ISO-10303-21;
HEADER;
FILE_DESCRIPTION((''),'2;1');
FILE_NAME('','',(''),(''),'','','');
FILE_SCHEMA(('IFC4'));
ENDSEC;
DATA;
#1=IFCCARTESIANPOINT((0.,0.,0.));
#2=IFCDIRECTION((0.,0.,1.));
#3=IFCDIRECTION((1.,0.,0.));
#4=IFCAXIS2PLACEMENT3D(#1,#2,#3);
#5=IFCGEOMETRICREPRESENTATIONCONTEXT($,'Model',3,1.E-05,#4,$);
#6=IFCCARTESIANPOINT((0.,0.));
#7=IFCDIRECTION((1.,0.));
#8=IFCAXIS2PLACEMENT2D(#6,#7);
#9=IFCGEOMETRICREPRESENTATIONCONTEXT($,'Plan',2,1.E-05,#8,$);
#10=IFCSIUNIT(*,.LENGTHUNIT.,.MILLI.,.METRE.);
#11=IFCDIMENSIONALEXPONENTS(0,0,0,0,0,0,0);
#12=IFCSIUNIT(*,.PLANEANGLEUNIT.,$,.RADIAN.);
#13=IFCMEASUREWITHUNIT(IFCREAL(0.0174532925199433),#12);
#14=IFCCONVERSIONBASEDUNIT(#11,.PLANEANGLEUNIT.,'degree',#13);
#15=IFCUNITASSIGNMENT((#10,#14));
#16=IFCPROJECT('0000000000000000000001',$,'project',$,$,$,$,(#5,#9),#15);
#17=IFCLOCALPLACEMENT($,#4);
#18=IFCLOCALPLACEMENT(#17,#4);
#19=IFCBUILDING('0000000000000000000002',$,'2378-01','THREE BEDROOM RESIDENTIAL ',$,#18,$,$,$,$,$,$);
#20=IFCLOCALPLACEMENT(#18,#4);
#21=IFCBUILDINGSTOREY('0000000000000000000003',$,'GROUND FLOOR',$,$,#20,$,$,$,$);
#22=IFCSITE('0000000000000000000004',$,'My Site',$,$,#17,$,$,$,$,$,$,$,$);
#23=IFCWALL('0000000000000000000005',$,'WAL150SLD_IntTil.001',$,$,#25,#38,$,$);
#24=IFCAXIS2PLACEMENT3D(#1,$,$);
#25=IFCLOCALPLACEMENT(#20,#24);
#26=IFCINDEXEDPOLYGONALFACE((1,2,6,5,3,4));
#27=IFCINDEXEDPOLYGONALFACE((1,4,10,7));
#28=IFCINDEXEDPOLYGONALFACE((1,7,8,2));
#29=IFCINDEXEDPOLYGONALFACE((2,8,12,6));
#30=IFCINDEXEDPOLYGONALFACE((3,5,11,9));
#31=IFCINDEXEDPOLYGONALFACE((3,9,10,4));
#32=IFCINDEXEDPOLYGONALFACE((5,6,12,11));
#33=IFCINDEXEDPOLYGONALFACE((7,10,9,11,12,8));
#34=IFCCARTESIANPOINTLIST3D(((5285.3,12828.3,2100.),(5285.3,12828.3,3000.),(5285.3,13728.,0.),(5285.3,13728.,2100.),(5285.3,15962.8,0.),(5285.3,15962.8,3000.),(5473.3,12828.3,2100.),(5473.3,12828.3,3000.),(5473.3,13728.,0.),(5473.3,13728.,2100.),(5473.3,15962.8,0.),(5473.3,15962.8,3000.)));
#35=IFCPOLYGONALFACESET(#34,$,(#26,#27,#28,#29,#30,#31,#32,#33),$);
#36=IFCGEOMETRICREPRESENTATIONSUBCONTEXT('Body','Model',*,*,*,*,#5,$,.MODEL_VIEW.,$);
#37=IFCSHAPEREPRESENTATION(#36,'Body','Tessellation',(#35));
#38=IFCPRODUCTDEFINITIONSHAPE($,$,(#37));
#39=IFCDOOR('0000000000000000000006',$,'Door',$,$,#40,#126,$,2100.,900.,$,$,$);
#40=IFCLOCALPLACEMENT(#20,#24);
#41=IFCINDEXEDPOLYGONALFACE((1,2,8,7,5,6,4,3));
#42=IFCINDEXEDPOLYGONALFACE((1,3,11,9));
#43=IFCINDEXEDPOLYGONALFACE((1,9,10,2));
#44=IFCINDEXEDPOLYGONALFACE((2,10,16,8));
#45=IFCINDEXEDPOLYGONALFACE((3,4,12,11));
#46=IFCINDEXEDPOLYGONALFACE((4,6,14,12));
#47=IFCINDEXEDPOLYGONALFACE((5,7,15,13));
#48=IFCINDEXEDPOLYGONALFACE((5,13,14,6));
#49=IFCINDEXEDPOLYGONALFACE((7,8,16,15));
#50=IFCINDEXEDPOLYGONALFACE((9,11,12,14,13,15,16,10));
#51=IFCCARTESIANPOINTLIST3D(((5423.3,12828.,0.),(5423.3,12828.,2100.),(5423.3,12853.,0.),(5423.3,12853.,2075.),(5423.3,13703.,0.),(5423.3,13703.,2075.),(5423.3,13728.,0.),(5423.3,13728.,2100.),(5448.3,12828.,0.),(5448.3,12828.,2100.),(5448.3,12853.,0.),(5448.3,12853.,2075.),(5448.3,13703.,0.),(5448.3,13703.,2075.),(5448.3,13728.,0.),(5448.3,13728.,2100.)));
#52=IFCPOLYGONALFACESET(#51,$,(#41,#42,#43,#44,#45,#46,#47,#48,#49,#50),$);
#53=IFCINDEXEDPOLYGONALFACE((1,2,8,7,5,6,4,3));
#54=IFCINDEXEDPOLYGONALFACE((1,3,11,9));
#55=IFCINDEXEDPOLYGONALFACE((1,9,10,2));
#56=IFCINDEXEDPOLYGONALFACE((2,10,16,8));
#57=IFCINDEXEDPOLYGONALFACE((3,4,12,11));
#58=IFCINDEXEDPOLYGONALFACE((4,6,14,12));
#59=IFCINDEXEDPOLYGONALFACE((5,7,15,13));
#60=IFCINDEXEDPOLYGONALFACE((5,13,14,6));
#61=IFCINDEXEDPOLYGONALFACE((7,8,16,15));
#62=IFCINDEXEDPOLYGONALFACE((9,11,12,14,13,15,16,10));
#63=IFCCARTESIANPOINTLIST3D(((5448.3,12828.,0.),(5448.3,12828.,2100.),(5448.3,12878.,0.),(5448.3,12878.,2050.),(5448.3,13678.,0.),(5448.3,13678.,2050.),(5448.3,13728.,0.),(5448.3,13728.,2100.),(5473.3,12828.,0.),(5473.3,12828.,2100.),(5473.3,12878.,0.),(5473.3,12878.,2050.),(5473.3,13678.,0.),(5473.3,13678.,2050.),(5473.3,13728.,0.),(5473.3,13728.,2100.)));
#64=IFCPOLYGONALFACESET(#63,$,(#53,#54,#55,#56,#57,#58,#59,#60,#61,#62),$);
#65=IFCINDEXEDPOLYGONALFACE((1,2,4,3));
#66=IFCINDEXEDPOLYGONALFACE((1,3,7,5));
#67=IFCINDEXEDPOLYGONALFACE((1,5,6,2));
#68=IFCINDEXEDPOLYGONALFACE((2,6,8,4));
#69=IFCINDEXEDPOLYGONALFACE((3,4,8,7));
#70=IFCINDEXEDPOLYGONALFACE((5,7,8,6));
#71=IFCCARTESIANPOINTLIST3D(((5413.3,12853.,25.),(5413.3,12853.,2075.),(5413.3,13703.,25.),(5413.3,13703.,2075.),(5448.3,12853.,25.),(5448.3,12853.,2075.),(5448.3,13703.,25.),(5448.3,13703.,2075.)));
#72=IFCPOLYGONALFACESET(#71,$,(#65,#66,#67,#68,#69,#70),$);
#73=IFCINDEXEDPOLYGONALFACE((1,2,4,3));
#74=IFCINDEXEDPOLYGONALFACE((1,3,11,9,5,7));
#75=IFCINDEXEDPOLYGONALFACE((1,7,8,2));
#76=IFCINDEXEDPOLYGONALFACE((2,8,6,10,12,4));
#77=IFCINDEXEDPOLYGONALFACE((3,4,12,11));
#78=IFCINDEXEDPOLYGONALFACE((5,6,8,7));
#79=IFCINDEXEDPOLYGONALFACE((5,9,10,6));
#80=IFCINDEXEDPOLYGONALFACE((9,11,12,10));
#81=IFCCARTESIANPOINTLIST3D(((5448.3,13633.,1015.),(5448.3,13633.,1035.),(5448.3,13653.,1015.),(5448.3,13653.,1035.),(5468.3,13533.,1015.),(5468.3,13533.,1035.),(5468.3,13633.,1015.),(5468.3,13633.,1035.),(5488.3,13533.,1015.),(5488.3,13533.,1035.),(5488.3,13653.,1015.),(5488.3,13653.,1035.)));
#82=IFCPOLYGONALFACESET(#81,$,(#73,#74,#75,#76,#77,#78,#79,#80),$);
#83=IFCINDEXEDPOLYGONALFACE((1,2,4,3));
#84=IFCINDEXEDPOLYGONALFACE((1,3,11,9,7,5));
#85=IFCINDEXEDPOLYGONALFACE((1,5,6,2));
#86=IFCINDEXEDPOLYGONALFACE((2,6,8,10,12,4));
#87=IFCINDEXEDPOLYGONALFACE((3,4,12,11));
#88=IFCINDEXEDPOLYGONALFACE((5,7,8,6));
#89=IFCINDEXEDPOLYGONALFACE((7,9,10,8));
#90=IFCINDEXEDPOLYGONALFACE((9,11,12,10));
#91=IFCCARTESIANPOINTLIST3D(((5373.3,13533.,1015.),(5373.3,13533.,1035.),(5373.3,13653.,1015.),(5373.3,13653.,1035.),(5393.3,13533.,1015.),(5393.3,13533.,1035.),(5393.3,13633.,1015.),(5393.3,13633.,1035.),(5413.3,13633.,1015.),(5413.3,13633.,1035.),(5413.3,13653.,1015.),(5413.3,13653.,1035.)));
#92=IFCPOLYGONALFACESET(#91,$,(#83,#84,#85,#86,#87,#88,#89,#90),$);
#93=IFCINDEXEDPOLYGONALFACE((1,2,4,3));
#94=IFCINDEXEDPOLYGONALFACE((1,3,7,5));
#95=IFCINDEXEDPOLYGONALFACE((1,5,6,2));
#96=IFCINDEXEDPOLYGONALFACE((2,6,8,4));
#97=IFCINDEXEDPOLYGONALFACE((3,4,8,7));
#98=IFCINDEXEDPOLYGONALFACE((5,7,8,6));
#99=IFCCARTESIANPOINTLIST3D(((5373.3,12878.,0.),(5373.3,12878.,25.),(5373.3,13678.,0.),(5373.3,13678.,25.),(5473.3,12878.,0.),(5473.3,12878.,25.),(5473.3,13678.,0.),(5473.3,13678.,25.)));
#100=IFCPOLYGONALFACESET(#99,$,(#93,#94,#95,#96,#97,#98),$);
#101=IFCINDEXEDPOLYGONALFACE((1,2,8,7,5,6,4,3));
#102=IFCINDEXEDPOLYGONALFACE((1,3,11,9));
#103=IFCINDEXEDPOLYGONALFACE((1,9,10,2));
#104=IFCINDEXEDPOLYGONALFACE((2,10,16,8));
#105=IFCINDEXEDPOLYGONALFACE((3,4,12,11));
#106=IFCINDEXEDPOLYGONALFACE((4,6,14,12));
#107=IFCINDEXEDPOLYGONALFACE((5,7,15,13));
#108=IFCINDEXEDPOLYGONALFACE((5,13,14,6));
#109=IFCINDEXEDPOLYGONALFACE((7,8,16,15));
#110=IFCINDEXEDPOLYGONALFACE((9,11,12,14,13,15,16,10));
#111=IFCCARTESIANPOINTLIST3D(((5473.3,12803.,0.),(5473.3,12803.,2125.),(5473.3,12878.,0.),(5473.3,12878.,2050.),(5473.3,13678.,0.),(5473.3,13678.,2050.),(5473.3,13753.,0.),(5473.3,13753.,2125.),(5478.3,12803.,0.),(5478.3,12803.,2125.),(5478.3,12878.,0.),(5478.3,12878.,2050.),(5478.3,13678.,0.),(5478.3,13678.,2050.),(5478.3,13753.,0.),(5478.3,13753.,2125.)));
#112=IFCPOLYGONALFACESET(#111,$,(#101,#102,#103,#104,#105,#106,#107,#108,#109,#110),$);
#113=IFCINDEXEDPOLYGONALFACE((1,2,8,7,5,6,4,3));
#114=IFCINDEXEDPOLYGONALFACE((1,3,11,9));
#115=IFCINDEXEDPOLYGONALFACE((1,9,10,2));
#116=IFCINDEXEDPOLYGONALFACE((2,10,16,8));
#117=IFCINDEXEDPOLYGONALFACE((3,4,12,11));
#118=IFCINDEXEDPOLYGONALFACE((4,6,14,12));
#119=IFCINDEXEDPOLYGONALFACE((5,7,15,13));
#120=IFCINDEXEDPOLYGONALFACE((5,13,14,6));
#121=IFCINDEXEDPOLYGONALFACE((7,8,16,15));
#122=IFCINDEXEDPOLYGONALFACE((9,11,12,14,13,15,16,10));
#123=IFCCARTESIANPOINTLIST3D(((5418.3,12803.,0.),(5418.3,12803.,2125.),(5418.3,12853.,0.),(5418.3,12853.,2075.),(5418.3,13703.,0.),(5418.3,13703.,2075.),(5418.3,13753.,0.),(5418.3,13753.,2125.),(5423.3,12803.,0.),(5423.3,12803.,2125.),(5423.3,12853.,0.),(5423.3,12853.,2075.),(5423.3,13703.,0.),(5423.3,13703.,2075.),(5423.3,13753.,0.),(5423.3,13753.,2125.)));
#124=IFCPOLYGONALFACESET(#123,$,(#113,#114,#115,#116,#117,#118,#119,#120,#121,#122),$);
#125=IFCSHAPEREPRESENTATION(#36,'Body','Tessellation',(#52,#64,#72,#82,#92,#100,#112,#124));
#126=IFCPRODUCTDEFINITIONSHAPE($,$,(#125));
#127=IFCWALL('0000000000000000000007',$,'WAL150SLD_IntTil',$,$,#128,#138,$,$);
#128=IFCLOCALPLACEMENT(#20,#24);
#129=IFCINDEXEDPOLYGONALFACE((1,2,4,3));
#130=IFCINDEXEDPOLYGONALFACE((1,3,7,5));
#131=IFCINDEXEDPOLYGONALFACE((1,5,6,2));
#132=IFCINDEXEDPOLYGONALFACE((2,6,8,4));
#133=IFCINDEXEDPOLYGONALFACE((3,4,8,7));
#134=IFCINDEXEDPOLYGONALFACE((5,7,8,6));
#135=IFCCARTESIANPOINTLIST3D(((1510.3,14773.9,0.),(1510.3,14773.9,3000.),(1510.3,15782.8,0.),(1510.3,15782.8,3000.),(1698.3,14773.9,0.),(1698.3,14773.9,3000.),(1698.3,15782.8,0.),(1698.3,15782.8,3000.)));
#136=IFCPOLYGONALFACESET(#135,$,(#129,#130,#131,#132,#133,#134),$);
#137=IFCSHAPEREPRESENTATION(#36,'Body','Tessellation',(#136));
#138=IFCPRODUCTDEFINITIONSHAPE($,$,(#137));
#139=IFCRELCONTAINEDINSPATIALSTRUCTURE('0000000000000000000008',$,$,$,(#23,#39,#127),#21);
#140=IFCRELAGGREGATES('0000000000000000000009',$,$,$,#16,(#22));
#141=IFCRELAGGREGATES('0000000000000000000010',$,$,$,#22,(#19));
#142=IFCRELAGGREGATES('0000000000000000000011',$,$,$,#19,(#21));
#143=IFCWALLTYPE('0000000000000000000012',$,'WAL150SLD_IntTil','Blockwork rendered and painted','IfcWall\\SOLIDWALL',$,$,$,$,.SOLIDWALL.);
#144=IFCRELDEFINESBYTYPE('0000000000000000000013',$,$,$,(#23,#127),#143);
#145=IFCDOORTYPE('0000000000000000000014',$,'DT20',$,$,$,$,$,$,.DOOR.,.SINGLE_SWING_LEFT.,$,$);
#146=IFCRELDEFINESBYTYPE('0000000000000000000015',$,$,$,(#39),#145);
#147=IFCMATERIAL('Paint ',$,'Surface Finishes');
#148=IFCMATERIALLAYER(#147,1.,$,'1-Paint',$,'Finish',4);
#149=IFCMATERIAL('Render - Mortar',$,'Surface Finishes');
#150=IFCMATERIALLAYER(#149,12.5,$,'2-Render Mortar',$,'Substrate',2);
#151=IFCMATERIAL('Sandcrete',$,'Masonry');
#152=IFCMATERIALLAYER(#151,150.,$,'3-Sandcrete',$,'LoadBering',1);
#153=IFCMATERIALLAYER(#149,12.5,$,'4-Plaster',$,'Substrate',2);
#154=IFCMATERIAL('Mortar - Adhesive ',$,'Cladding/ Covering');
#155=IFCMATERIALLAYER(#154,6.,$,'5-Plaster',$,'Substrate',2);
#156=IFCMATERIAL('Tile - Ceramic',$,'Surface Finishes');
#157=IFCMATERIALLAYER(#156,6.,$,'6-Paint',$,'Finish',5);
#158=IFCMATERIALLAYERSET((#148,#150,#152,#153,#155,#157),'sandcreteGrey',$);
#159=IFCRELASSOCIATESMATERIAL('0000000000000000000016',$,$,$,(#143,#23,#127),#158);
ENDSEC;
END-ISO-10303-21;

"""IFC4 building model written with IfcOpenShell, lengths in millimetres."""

from ifc_helpers import new_model, entity, si_unit, converted_unit, frame, origin_with_axes, origin_2d_with_axis, place, context, subcontext, project, spatial, line, indexed_curve, outline, extrude, shape, source, transform, mapped, material, layer, layer_set, layer_usage, type_object, type_shapes, element, fill, save


model = new_model("IFC4")

# Units and contexts
model_context = context("Model", 3, precision=1e-05, world=origin_with_axes())
plan_context = context("Plan", 2, precision=1e-05, world=origin_2d_with_axis())
body_context_1 = subcontext(model_context, "Body", "Model", "MODEL_VIEW")
body_context_2 = subcontext(plan_context, "Body", "Plan", "PLAN_VIEW")
ifc_project = project(units=[si_unit("LENGTHUNIT", "METRE", prefix="MILLI"), converted_unit("PLANEANGLEUNIT", "degree", entity("IfcReal", 0.0174532925199433), si_unit("PLANEANGLEUNIT", "RADIAN"), dimensions=[0, 0, 0, 0, 0, 0, 0])], contexts=[model_context, plan_context])

# Site, building, storey
site_placement = place(None, origin_with_axes())
site = spatial("IfcSite", under=ifc_project, at=site_placement, Name="My Site")
building_placement = place(site_placement, origin_with_axes())
building = spatial("IfcBuilding", under=site, at=building_placement, Name="2378-01", Description="THREE BEDROOM RESIDENTIAL ")
storey_placement = place(building_placement, origin_with_axes())
storey = spatial("IfcBuildingStorey", under=building, at=storey_placement, Name="GROUND FLOOR")

# Shared definitions
ifc_material_1 = material(Name="Paint ", Category="Surface Finishes")
ifc_material_2 = material(Name="Render - Mortar", Category="Surface Finishes")
ifc_material_3 = material(Name="Sandcrete", Category="Masonry")

# Shared definitions
ifc_material_4 = material(Name="Mortar - Adhesive ", Category="Cladding/ Covering")
ifc_material_5 = material(Name="Tile - Ceramic", Category="Surface Finishes")

# Shared definitions
ifc_layer_1 = layer(ifc_material_1, 1.0, Name="1-Paint", Category="Finish", Priority=4)
ifc_layer_2 = layer(ifc_material_2, 12.5, Name="2-Render Mortar", Category="Substrate", Priority=2)
ifc_layer_3 = layer(ifc_material_3, 150.0, Name="3-Sandcrete", Category="LoadBering", Priority=1)
ifc_layer_4 = layer(ifc_material_2, 12.5, Name="4-Plaster", Category="Substrate", Priority=2)
ifc_layer_5 = layer(ifc_material_4, 6.0, Name="5-Plaster", Category="Substrate", Priority=2)
ifc_layer_6 = layer(ifc_material_5, 6.0, Name="6-Paint", Category="Finish", Priority=5)
ifc_layer_set_1 = layer_set([ifc_layer_1, ifc_layer_2, ifc_layer_3, ifc_layer_4, ifc_layer_5, ifc_layer_6], Name="sandcreteGrey")
wall_type_1 = type_object("IfcWallType", Name="WAL150SLD_IntTil", Description="Blockwork rendered and painted", ApplicableOccurrence="IfcWall\\SOLIDWALL", PredefinedType="SOLIDWALL", material=ifc_layer_set_1)

# Wall, opening, door
ifc_layer_usage_1 = layer_usage(ifc_layer_set_1, "AXIS2", "POSITIVE", 0.0)
wall_1_placement = place(storey_placement, frame((5473.3, 12828.3, 0.0), z_axis=(0.0, 0.0, 1.0), x_axis=(0.000001, 1.0, 0.0)))
wall_1 = element("IfcWall", 1, at=wall_1_placement, inside=storey, type_object=wall_type_1, material=ifc_layer_usage_1, Name="WAL150SLD_IntTil.001", context=body_context_1, shape_type="SweptSolid", body=[
    extrude(outline(indexed_curve([(0.0, 0.0), (0.0, 188.0), (3134.5, 188.0), (3134.5, 0.0), (0.0, 0.0)], self_intersect=False)), origin_with_axes(), (0.0, 0.0, 1.0), 3000.0),
])
shared_shape_1 = source(origin_with_axes(), body_context_1, "Body", "SweptSolid", [
    extrude(outline(indexed_curve([(0.0, 0.0), (900.0, 0.0), (900.0, 2100.0), (0.0, 2100.0)], segments=[line(1, 2, 3, 4, 1)])), frame((0.0, -100.0, 0.0), z_axis=(0.0, -1.0, 0.0), x_axis=(1.0, 0.0, 0.0)), (0.0, 0.0, -1.0), 380.0),
])
opening_1_placement = place(wall_1_placement, frame((-0.3, 0.0, 0.0), z_axis=(0.0, 0.0, 1.0), x_axis=(1.0, 0.0, 0.0)))
opening_1 = element("IfcOpeningElement", 2, at=opening_1_placement, cuts=wall_1, PredefinedType="OPENING", context=body_context_1, shape_type="MappedRepresentation", body=[
    mapped(shared_shape_1, transform((0.0, 0.0, 0.0), x_axis=(1.0, 0.0, 0.0), y_axis=(0.0, 1.0, 0.0), z_axis=(0.0, 0.0, 1.0), scale=1.0)),
])
door_type_1 = type_object("IfcDoorType", Name="DT20", OperationType="SINGLE_SWING_LEFT", PredefinedType="DOOR")
shared_shape_2 = source(origin_with_axes(), body_context_1, "Body", "SweptSolid", [
    extrude(outline(indexed_curve([(0.0, 0.0), (0.0, 2100.0), (900.0, 2100.0), (900.0, 0.0), (875.0, 0.0), (875.0, 2075.0), (25.0, 2075.0), (25.0, 0.0)], segments=[line(1, 2, 3, 4, 5, 6, 7, 8, 1)])), frame((0.0, 25.0, 0.0), z_axis=(0.0, -1.0, 0.0), x_axis=(1.0, 0.0, 0.0)), (0.0, 0.0, -1.0), 25.0),
    extrude(outline(indexed_curve([(0.0, 0.0), (0.0, 2100.0), (900.0, 2100.0), (900.0, 0.0), (850.0, 0.0), (850.0, 2050.0), (50.0, 2050.0), (50.0, 0.0)], segments=[line(1, 2, 3, 4, 5, 6, 7, 8, 1)])), frame((0.0, 0.0, 0.0), z_axis=(0.0, -1.0, 0.0), x_axis=(1.0, 0.0, 0.0)), (0.0, 0.0, -1.0), 25.0),
    extrude(outline(indexed_curve([(0.0, 0.0), (850.0, 0.0), (850.0, 35.0), (0.0, 35.0)], segments=[line(1, 2, 3, 4, 1)])), frame((25.0, 25.0, 25.0), z_axis=(0.0, 0.0, 1.0), x_axis=(1.0, 0.0, 0.0)), (0.0, 0.0, 1.0), 2050.0),
    extrude(outline(indexed_curve([(0.0, 0.0), (0.0, -40.0), (-120.0, -40.0), (-120.0, -20.0), (-20.0, -20.0), (-20.0, 0.0)], segments=[line(1, 2, 3, 4, 5, 6, 1)])), frame((825.0, 25.0, 1015.0), z_axis=(0.0, 0.0, 1.0), x_axis=(1.0, 0.0, 0.0)), (0.0, 0.0, 1.0), 20.0),
    extrude(outline(indexed_curve([(0.0, 0.0), (0.0, 40.0), (-120.0, 40.0), (-120.0, 20.0), (-20.0, 20.0), (-20.0, 0.0)], segments=[line(1, 2, 3, 4, 5, 6, 1)])), frame((825.0, 60.0, 1015.0), z_axis=(0.0, 0.0, 1.0), x_axis=(1.0, 0.0, 0.0)), (0.0, 0.0, 1.0), 20.0),
    extrude(outline(indexed_curve([(0.0, 0.0), (800.0, 0.0), (800.0, 100.0), (0.0, 100.0)], segments=[line(1, 2, 3, 4, 1)])), frame((50.0, 0.0, 0.0), z_axis=(0.0, 0.0, 1.0), x_axis=(1.0, 0.0, 0.0)), (0.0, 0.0, 1.0), 25.0),
    extrude(outline(indexed_curve([(0.0, 0.0), (0.0, 2125.0), (950.0, 2125.0), (950.0, 0.0), (875.0, 0.0), (875.0, 2050.0), (75.0, 2050.0), (75.0, 0.0)], segments=[line(1, 2, 3, 4, 5, 6, 7, 8, 1)])), frame((-25.0, -5.0, 0.0), z_axis=(0.0, -1.0, 0.0), x_axis=(1.0, 0.0, 0.0)), (0.0, 0.0, -1.0), 5.0),
    extrude(outline(indexed_curve([(0.0, 0.0), (0.0, 2125.0), (950.0, 2125.0), (950.0, 0.0), (900.0, 0.0), (900.0, 2075.0), (50.0, 2075.0), (50.0, 0.0)], segments=[line(1, 2, 3, 4, 5, 6, 7, 8, 1)])), frame((-25.0, 50.0, 0.0), z_axis=(0.0, -1.0, 0.0), x_axis=(1.0, 0.0, 0.0)), (0.0, 0.0, -1.0), 5.0),
])
shared_shape_3 = source(origin_with_axes(), body_context_2, "Body", "Curve2D", [
    entity("IfcIndexedPolyCurve", entity("IfcCartesianPointList2D", [[0.0, 0.0], [0.0, 50.0], [25.0, 50.0], [25.0, 25.0], [50.0, 25.0], [50.0, 0.0]]), [entity("IfcLineIndex", [1, 2, 3, 4, 5, 6, 1])]),
    entity("IfcIndexedPolyCurve", entity("IfcCartesianPointList2D", [[900.0, 0.0], [900.0, 50.0], [875.0, 50.0], [875.0, 25.0], [850.0, 25.0], [850.0, 0.0]]), [entity("IfcLineIndex", [1, 2, 3, 4, 5, 6, 1])]),
    entity("IfcTrimmedCurve", entity("IfcEllipse", entity("IfcAxis2Placement2D", entity("IfcCartesianPoint", [60.0, 50.0]), entity("IfcDirection", [1.0, 0.0])), 815.0, 850.0), [entity("IfcCartesianPoint", [875.0, 50.0])], [entity("IfcCartesianPoint", [60.0, 900.0])], True, "CARTESIAN"),
    entity("IfcIndexedPolyCurve", entity("IfcCartesianPointList2D", [[25.0, 50.0], [60.0, 50.0], [60.0, 900.0], [25.0, 900.0]]), [entity("IfcLineIndex", [1, 2, 3, 4, 1])]),
])
type_shapes(door_type_1, [shared_shape_2, shared_shape_3])
door_1_placement = place(opening_1_placement, frame((0.0, 0.0, 0.0), z_axis=(0.0, 0.0, 1.0), x_axis=(1.0, 0.0, 0.0)))
door_1 = element("IfcDoor", 3, at=door_1_placement, inside=storey, type_object=door_type_1, Name="Door", OverallHeight=2100.0, OverallWidth=900.0, shapes=[
    shape(body_context_1, "Body", "MappedRepresentation", [mapped(shared_shape_2, transform((0.0, 0.0, 0.0), x_axis=(1.0, 0.0, 0.0), y_axis=(0.0, 1.0, 0.0), z_axis=(0.0, 0.0, 1.0), scale=1.0))]),
    shape(body_context_2, "Body", "MappedRepresentation", [mapped(shared_shape_3, transform((0.0, 0.0, 0.0), x_axis=(1.0, 0.0, 0.0), y_axis=(0.0, 1.0, 0.0), z_axis=(0.0, 0.0, 1.0), scale=1.0))]),
])
fill(opening_1, door_1)

# Wall
ifc_layer_usage_2 = layer_usage(ifc_layer_set_1, "AXIS2", "POSITIVE", 0.0)
wall_2_placement = place(storey_placement, frame((1510.3, 15782.8, 0.0), z_axis=(0.0, 0.0, 1.0), x_axis=(-0.000001, -1.0, 0.0)))
element("IfcWall", 4, at=wall_2_placement, inside=storey, type_object=wall_type_1, material=ifc_layer_usage_2, Name="WAL150SLD_IntTil", context=body_context_1, shape_type="SweptSolid", body=[
    extrude(outline(indexed_curve([(0.0, 0.0), (0.0, 188.0), (1008.9, 188.0), (1008.9, 0.0), (0.0, 0.0)], self_intersect=False)), origin_with_axes(), (0.0, 0.0, 1.0), 3000.0),
])

save(model, "model.ifc")
